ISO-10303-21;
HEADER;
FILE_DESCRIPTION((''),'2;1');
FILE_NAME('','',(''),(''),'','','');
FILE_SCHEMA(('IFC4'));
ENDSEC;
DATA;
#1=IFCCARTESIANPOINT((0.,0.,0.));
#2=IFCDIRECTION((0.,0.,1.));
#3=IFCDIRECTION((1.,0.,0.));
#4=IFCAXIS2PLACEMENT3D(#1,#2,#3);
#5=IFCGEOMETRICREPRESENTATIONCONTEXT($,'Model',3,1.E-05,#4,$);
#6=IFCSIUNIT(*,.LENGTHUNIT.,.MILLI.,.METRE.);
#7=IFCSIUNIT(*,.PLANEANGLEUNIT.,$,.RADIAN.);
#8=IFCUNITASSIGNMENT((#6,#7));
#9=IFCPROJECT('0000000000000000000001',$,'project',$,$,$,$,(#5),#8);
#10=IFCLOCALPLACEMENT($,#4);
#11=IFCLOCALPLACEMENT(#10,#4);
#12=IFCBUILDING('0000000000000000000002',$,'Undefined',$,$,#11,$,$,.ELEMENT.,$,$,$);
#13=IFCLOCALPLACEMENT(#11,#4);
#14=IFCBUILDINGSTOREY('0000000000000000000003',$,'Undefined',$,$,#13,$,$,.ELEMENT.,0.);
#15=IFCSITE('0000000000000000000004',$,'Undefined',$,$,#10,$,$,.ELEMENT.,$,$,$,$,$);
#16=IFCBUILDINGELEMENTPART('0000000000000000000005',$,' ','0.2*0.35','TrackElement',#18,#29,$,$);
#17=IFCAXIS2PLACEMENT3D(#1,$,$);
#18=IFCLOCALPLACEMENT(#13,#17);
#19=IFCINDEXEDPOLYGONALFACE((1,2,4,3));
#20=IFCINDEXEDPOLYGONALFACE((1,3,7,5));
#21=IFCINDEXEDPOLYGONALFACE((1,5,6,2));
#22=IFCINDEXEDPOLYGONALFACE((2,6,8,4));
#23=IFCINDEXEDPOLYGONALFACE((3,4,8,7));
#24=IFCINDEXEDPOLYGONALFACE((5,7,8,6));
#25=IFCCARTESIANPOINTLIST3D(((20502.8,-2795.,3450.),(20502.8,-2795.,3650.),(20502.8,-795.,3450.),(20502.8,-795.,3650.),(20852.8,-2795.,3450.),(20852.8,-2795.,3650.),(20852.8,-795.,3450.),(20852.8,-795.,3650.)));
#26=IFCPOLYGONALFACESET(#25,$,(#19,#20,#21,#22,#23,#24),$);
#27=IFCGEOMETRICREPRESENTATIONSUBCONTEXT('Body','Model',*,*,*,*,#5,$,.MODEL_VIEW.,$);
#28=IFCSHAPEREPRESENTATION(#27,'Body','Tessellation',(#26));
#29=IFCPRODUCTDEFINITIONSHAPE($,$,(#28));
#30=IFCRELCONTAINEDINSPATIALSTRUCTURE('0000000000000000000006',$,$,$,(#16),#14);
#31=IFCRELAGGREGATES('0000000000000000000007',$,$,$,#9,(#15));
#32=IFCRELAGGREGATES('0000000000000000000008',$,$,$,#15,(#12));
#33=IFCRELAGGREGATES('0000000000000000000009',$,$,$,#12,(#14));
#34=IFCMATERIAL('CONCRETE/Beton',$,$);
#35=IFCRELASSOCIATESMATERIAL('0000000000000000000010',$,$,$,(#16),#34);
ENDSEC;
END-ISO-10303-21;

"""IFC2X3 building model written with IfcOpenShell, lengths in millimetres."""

from ifc_helpers import new_model, si_unit, frame, origin_with_axes, origin_2d_with_axis, place, context, subcontext, project, spatial, rectangle, extrude, material, element, save


model = new_model("IFC2X3")

# Units and contexts
model_context = context("Model", 3, precision=1e-05, world=origin_with_axes())
body_context = subcontext(model_context, "Body", "Model", "MODEL_VIEW")
ifc_project = project(units=[si_unit("LENGTHUNIT", "METRE", prefix="MILLI"), si_unit("PLANEANGLEUNIT", "RADIAN")], contexts=[model_context])

# Site, building, storey
site_placement = place(None, origin_with_axes())
site = spatial("IfcSite", under=ifc_project, at=site_placement, Name="Undefined", CompositionType="ELEMENT")
building_placement = place(site_placement, origin_with_axes())
building = spatial("IfcBuilding", under=site, at=building_placement, Name="Undefined", CompositionType="ELEMENT")
storey_placement = place(building_placement, origin_with_axes())
storey = spatial("IfcBuildingStorey", under=building, at=storey_placement, Name="Undefined", CompositionType="ELEMENT", Elevation=0.0)

# Shared definitions
ifc_material_1 = material(Name="CONCRETE/Beton")

# Building element part
building_element_part_placement = place(storey_placement, frame((20677.8, -795.0, 3550.0), z_axis=(0.0, 0.0, 1.0), x_axis=(0.0, -1.0, 0.0)))
element("IfcBuildingElementPart", 1, at=building_element_part_placement, inside=storey, material=ifc_material_1, Name=" ", Description="0.2*0.35", ObjectType="TrackElement", context=body_context, shape_type="SweptSolid", body=[
    extrude(rectangle(XDim=350.0, YDim=200.0, at=origin_2d_with_axis()), frame((2000.0, 0.0, 0.0), z_axis=(-1.0, 0.0, 0.0), x_axis=(0.0, -1.0, 0.0)), (0.0, 0.0, 1.0), 2000.0),
])

save(model, "model.ifc")
